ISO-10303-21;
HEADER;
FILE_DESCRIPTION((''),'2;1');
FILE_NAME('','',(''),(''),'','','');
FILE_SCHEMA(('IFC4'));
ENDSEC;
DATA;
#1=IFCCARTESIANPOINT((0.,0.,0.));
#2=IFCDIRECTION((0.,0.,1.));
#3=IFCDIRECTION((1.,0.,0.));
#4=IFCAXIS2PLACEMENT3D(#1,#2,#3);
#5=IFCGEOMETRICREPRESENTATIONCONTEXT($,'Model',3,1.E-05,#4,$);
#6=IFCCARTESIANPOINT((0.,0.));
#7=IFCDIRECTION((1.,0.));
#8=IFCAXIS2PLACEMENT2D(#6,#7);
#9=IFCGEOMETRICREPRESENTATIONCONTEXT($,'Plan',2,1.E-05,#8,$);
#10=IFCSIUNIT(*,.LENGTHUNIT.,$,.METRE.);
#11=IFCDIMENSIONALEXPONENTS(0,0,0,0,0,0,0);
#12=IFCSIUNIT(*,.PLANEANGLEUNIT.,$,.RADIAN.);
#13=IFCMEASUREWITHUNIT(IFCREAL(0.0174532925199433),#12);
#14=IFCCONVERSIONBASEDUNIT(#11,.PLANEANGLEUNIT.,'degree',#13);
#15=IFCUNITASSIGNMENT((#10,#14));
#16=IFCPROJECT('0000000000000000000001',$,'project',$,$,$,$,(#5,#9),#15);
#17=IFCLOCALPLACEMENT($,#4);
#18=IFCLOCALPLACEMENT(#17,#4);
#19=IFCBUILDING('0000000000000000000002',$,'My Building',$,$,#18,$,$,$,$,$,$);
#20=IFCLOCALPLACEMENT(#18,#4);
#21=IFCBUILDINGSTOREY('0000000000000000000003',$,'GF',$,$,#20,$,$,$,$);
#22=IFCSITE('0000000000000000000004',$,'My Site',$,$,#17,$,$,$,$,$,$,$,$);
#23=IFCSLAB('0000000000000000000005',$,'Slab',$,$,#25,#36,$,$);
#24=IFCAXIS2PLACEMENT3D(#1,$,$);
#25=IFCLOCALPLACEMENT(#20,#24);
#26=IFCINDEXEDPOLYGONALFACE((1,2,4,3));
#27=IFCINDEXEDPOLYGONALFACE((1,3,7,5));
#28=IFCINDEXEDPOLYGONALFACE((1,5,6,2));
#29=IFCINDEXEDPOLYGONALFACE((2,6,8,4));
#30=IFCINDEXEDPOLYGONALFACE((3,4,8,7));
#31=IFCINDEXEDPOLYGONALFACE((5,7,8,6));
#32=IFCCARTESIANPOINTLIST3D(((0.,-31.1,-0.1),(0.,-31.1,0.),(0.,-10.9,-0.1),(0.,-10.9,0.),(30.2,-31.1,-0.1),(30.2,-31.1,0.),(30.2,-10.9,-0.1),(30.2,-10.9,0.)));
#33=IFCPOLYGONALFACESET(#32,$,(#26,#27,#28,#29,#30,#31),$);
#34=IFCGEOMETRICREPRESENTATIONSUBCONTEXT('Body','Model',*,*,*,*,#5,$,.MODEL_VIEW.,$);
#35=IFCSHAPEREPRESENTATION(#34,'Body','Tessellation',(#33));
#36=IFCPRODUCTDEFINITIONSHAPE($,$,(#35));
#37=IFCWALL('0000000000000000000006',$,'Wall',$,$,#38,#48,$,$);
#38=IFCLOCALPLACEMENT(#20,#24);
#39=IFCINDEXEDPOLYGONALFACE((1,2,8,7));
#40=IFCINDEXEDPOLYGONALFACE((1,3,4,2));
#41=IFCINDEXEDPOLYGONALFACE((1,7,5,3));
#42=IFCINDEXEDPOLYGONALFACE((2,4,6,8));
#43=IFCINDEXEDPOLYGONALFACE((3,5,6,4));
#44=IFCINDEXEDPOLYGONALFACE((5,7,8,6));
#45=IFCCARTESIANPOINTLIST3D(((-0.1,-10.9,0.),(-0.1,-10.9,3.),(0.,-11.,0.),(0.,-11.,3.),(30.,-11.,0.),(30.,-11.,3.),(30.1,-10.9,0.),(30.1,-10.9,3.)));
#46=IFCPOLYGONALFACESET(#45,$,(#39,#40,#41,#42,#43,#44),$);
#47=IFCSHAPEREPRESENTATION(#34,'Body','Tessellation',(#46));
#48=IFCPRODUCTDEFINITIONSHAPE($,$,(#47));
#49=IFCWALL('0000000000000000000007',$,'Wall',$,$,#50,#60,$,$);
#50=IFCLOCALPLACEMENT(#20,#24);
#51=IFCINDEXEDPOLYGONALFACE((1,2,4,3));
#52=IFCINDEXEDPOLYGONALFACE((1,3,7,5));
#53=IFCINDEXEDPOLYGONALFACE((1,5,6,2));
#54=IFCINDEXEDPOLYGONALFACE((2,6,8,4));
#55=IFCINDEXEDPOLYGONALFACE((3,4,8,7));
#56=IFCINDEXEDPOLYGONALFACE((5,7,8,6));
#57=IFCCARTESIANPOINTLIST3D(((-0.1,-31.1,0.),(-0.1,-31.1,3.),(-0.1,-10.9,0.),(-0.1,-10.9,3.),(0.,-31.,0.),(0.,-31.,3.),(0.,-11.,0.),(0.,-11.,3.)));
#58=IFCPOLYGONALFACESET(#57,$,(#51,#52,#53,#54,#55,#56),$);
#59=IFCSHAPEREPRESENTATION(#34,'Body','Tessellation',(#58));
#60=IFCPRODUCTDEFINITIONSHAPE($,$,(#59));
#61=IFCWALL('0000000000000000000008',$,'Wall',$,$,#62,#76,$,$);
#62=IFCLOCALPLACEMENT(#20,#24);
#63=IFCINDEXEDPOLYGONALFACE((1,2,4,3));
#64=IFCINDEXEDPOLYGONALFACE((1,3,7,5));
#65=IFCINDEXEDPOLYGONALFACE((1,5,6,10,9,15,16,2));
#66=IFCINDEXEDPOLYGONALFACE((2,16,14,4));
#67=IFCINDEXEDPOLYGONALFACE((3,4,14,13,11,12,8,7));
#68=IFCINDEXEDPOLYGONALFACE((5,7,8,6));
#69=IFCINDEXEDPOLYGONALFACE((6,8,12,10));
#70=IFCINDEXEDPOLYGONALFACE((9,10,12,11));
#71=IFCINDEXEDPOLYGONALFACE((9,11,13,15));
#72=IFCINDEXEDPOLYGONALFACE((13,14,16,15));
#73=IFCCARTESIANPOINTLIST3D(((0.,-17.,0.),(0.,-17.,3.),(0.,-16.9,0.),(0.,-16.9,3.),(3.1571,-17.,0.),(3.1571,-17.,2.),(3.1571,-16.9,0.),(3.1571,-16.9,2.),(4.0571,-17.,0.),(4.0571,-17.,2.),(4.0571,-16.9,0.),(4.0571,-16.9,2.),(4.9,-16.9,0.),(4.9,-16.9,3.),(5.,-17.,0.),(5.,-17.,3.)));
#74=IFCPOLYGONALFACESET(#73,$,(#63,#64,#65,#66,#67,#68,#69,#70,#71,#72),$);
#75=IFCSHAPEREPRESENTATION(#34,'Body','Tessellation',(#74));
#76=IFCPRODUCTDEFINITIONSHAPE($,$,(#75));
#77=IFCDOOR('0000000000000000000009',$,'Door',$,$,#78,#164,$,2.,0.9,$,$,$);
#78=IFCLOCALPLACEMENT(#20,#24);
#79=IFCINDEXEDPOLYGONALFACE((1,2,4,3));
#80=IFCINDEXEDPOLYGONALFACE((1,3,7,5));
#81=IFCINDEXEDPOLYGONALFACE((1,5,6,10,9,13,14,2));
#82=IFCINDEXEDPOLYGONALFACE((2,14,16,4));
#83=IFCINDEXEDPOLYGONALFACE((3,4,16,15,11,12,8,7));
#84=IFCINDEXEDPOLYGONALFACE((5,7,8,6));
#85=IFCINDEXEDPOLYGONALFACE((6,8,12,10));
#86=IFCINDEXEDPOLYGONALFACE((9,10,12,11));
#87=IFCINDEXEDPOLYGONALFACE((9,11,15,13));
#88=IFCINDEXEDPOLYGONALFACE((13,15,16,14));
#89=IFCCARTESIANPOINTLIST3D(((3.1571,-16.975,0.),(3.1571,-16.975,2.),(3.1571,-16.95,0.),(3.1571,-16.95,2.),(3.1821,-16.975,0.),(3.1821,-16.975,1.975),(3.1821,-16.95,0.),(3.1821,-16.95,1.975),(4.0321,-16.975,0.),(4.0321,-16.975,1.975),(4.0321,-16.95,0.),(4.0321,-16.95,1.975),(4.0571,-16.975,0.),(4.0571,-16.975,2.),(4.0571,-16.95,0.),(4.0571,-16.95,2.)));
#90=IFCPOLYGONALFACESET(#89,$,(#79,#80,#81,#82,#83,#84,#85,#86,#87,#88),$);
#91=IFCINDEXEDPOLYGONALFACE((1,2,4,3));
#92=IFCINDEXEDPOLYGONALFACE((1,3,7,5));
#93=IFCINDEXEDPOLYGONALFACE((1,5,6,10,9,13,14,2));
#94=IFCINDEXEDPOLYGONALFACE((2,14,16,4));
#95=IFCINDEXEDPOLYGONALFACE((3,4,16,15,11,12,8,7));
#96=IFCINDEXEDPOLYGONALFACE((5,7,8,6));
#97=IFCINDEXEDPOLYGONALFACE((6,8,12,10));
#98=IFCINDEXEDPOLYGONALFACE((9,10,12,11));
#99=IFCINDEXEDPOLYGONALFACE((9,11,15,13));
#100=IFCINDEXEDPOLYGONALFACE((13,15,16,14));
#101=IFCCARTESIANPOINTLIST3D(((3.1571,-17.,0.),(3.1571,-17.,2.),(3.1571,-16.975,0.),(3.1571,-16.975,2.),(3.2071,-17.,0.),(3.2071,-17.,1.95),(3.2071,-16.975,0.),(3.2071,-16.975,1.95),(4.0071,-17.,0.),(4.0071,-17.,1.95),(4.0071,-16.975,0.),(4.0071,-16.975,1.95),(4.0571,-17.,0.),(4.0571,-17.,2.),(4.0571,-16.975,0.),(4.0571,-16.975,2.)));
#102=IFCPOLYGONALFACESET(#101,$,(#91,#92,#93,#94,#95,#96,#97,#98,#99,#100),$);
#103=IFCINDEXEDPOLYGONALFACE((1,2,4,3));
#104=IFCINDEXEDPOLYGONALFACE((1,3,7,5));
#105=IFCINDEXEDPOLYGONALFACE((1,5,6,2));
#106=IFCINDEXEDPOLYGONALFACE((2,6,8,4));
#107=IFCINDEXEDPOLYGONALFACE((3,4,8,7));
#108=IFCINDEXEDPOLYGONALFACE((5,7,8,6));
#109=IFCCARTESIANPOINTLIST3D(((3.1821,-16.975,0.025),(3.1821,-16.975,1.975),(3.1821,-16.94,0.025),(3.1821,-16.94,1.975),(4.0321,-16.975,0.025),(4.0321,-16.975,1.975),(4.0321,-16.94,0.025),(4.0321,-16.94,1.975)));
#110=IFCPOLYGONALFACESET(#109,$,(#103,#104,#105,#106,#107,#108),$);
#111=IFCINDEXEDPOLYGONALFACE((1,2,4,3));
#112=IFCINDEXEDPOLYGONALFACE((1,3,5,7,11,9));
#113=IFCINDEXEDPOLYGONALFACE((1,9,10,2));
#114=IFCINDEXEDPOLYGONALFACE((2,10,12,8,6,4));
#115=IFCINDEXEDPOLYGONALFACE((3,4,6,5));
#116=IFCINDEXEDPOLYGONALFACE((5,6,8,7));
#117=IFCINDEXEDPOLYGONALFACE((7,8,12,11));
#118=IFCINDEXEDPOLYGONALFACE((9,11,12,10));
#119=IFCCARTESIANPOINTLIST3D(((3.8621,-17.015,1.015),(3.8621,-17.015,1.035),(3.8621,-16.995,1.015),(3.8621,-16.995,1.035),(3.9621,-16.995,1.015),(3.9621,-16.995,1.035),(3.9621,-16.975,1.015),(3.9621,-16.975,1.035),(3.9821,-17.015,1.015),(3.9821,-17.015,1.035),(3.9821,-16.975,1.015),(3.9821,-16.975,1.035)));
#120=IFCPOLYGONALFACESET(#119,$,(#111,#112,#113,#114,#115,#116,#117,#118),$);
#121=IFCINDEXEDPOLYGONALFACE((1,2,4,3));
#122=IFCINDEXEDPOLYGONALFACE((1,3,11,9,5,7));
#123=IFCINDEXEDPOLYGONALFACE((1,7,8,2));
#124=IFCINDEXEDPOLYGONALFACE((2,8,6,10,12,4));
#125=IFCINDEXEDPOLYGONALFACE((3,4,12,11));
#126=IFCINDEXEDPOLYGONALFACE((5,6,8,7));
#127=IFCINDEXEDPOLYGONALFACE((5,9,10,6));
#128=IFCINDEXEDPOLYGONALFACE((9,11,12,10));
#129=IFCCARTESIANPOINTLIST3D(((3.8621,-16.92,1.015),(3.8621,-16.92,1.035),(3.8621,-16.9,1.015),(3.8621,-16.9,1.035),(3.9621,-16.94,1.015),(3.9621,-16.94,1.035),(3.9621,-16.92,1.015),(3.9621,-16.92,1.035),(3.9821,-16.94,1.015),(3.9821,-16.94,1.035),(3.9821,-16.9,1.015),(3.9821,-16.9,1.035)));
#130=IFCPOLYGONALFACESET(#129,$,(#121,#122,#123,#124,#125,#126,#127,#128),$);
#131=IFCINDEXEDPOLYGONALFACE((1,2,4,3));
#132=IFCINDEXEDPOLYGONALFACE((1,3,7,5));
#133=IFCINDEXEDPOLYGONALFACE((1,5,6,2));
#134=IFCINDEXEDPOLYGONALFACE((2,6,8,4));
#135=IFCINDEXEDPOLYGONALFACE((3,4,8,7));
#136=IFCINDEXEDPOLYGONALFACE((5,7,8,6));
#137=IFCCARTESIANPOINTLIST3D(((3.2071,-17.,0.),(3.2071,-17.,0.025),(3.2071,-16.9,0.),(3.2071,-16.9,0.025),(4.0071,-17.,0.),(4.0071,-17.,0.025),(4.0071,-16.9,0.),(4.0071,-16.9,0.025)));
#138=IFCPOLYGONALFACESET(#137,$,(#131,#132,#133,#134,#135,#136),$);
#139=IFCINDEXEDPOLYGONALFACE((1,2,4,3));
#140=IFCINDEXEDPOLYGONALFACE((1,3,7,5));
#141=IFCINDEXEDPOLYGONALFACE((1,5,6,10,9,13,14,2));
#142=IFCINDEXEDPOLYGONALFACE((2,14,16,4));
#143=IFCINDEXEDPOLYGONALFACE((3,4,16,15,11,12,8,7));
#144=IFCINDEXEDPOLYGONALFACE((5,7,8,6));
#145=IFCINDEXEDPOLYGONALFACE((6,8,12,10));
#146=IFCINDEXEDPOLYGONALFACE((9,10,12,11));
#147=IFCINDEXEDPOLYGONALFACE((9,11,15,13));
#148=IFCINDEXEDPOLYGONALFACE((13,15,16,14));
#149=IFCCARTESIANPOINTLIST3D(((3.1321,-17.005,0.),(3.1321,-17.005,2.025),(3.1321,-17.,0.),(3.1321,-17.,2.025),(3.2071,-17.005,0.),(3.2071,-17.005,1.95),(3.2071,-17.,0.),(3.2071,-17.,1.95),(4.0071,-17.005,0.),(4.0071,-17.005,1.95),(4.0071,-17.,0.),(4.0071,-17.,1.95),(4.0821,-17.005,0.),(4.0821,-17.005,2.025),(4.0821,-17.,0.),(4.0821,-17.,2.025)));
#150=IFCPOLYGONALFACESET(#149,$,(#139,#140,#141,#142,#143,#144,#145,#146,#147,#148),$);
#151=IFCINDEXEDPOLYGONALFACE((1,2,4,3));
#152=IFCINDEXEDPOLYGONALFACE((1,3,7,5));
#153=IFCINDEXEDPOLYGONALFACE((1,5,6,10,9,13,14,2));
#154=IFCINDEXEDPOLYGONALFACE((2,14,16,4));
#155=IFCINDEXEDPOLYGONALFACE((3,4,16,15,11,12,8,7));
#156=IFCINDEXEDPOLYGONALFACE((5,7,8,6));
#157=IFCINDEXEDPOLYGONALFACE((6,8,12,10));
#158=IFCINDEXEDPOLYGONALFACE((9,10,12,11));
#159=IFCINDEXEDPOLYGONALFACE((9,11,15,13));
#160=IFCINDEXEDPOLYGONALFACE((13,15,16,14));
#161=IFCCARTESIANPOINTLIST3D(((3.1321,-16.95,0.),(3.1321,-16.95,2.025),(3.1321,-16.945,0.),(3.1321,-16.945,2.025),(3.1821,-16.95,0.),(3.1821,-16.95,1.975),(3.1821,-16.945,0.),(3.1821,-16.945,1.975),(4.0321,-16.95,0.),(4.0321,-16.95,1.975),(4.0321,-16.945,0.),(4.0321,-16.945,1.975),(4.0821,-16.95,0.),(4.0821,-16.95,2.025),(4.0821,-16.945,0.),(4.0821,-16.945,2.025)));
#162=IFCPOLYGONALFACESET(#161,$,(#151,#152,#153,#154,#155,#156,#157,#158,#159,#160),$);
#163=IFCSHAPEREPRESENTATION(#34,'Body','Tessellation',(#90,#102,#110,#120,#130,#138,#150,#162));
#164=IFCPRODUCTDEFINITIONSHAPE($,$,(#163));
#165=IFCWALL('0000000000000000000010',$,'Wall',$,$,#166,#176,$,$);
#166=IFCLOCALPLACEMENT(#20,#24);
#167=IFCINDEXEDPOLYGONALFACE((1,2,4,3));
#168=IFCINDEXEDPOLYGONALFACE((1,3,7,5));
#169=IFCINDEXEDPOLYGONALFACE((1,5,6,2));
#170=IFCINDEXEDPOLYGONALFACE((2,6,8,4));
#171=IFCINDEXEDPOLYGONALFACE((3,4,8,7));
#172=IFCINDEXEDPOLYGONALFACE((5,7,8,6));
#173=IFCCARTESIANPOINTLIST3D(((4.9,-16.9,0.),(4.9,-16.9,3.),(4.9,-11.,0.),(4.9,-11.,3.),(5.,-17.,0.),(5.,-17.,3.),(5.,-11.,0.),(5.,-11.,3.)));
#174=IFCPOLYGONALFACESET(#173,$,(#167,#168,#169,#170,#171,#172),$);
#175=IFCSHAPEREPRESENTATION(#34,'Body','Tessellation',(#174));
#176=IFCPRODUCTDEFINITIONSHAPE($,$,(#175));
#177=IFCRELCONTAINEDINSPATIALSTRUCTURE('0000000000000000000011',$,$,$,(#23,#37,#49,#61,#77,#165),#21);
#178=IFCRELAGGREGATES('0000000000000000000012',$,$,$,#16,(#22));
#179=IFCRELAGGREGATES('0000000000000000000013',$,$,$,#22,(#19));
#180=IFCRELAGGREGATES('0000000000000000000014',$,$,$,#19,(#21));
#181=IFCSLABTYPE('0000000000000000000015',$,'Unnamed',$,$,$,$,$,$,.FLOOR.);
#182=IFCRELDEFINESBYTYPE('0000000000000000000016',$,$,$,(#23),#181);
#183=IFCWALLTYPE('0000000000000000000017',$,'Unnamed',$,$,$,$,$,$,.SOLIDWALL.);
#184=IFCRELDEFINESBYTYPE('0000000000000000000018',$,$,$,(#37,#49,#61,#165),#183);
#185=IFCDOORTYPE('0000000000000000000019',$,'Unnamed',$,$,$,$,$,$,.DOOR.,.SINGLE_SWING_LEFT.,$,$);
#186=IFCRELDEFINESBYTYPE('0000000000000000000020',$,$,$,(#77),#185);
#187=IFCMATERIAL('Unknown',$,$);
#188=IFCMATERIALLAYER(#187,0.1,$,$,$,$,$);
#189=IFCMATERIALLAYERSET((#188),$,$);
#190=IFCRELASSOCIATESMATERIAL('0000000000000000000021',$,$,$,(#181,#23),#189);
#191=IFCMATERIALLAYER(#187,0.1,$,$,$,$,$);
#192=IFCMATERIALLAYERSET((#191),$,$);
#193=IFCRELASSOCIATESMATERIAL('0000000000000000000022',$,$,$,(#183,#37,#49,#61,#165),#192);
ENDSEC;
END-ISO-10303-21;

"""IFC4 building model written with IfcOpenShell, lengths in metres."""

from ifc_helpers import new_model, entity, si_unit, converted_unit, frame, origin_with_axes, origin_2d_with_axis, place, context, subcontext, project, spatial, line, indexed_curve, outline, extrude, shape, source, transform, mapped, material, layer, layer_set, layer_usage, type_object, type_shapes, element, fill, save


model = new_model("IFC4")

# Units and contexts
model_context = context("Model", 3, precision=1e-05, world=origin_with_axes())
plan_context = context("Plan", 2, precision=1e-05, world=origin_2d_with_axis())
body_context_1 = subcontext(model_context, "Body", "Model", "MODEL_VIEW")
body_context_2 = subcontext(plan_context, "Body", "Plan", "PLAN_VIEW")
ifc_project = project(units=[si_unit("LENGTHUNIT", "METRE"), converted_unit("PLANEANGLEUNIT", "degree", entity("IfcReal", 0.0174532925199433), si_unit("PLANEANGLEUNIT", "RADIAN"), dimensions=[0, 0, 0, 0, 0, 0, 0])], contexts=[model_context, plan_context])

# Site, building, storey
site_placement = place(None, origin_with_axes())
site = spatial("IfcSite", under=ifc_project, at=site_placement, Name="My Site")
building_placement = place(site_placement, origin_with_axes())
building = spatial("IfcBuilding", under=site, at=building_placement, Name="My Building")
storey_placement = place(building_placement, origin_with_axes())
storey = spatial("IfcBuildingStorey", under=building, at=storey_placement, Name="GF")

# Slab
ifc_material = material(Name="Unknown")
ifc_layer_1 = layer(ifc_material, 0.1)
ifc_layer_set_1 = layer_set([ifc_layer_1])
ifc_layer_usage_1 = layer_usage(ifc_layer_set_1, "AXIS3", "POSITIVE", -0.1)
slab_type = type_object("IfcSlabType", Name="Unnamed", PredefinedType="FLOOR", material=ifc_layer_set_1)
slab_placement = place(storey_placement, frame((0.0, -10.9, 0.0), z_axis=(0.0, 0.0, 1.0), x_axis=(1.0, 0.0, 0.0)))
element("IfcSlab", 1, at=slab_placement, inside=storey, type_object=slab_type, material=ifc_layer_usage_1, Name="Slab", context=body_context_1, shape_type="SweptSolid", body=[
    extrude(outline(indexed_curve([(0.0, 0.0), (30.2, 0.0), (30.2, -20.2), (0.0, -20.2), (0.0, 0.0)])), frame((0.0, 0.0, -0.1), z_axis=(0.0, 0.0, 1.0), x_axis=(1.0, 0.0, 0.0)), (0.0, 0.0, 1.0), 0.1),
])

# Walls
ifc_layer_2 = layer(ifc_material, 0.1)
ifc_layer_set_2 = layer_set([ifc_layer_2])
ifc_layer_usage_2 = layer_usage(ifc_layer_set_2, "AXIS2", "POSITIVE", 0.0)
wall_type = type_object("IfcWallType", Name="Unnamed", PredefinedType="SOLIDWALL", material=ifc_layer_set_2)
wall_1_placement = place(storey_placement, frame((0.0, -11.0, 0.0), z_axis=(0.0, 0.0, 1.0), x_axis=(1.0, 0.0, 0.0)))
element("IfcWall", 2, at=wall_1_placement, inside=storey, type_object=wall_type, material=ifc_layer_usage_2, Name="Wall", context=body_context_1, shape_type="SweptSolid", body=[
    extrude(outline(indexed_curve([(0.0, 0.0), (-0.1, 0.1), (30.1, 0.1), (30.0, 0.0)], segments=[line(1, 2, 3, 4, 1)])), origin_with_axes(), (0.0, 0.0, 1.0), 3.0),
])
ifc_layer_usage_3 = layer_usage(ifc_layer_set_2, "AXIS2", "POSITIVE", 0.0)
wall_2_placement = place(storey_placement, frame((0.0, -31.0, 0.0), z_axis=(0.0, 0.0, 1.0), x_axis=(0.0, 1.0, 0.0)))
element("IfcWall", 3, at=wall_2_placement, inside=storey, type_object=wall_type, material=ifc_layer_usage_3, Name="Wall", context=body_context_1, shape_type="SweptSolid", body=[
    extrude(outline(indexed_curve([(0.0, 0.0), (-0.1, 0.1), (20.1, 0.1), (20.0, 0.0)], segments=[line(1, 2, 3, 4, 1)])), origin_with_axes(), (0.0, 0.0, 1.0), 3.0),
])

# Wall, opening, door
ifc_layer_usage_4 = layer_usage(ifc_layer_set_2, "AXIS2", "POSITIVE", 0.0)
wall_3_placement = place(storey_placement, frame((0.0, -17.0, 0.0), z_axis=(0.0, 0.0, 1.0), x_axis=(1.0, 0.0, 0.0)))
wall_3 = element("IfcWall", 4, at=wall_3_placement, inside=storey, type_object=wall_type, material=ifc_layer_usage_4, Name="Wall", context=body_context_1, shape_type="SweptSolid", body=[
    extrude(outline(indexed_curve([(0.0, 0.0), (0.0, 0.1), (4.9, 0.1), (5.0, 0.0)], segments=[line(1, 2, 3, 4, 1)])), origin_with_axes(), (0.0, 0.0, 1.0), 3.0),
])
shared_shape_1 = source(origin_with_axes(), body_context_1, "Body", "SweptSolid", [
    extrude(outline(indexed_curve([(0.0, 0.0), (0.9, 0.0), (0.9, 2.0), (0.0, 2.0)], segments=[line(1, 2, 3, 4, 1)])), frame((0.0, -0.6, 0.0), z_axis=(0.0, -1.0, 0.0), x_axis=(1.0, 0.0, 0.0)), (0.0, 0.0, -1.0), 1.2),
])
opening_1_placement = place(wall_3_placement, frame((3.1571, 0.0, 0.0), z_axis=(0.0, 0.0, 1.0), x_axis=(1.0, 0.0, 0.0)))
opening_1 = element("IfcOpeningElement", 5, at=opening_1_placement, cuts=wall_3, PredefinedType="OPENING", context=body_context_1, shape_type="MappedRepresentation", body=[
    mapped(shared_shape_1, transform((0.0, 0.0, 0.0), x_axis=(1.0, 0.0, 0.0), y_axis=(0.0, 1.0, 0.0), z_axis=(0.0, 0.0, 1.0), scale=1.0)),
])
door_type = type_object("IfcDoorType", Name="Unnamed", OperationType="SINGLE_SWING_LEFT", PredefinedType="DOOR")
shared_shape_2 = source(origin_with_axes(), body_context_1, "Body", "SweptSolid", [
    extrude(outline(indexed_curve([(0.0, 0.0), (0.0, 2.0), (0.9, 2.0), (0.9, 0.0), (0.875, 0.0), (0.875, 1.975), (0.025, 1.975), (0.025, 0.0)], segments=[line(1, 2, 3, 4, 5, 6, 7, 8, 1)])), frame((0.0, 0.025, 0.0), z_axis=(0.0, -1.0, 0.0), x_axis=(1.0, 0.0, 0.0)), (0.0, 0.0, -1.0), 0.025),
    extrude(outline(indexed_curve([(0.0, 0.0), (0.0, 2.0), (0.9, 2.0), (0.9, 0.0), (0.85, 0.0), (0.85, 1.95), (0.05, 1.95), (0.05, 0.0)], segments=[line(1, 2, 3, 4, 5, 6, 7, 8, 1)])), frame((0.0, 0.0, 0.0), z_axis=(0.0, -1.0, 0.0), x_axis=(1.0, 0.0, 0.0)), (0.0, 0.0, -1.0), 0.025),
    extrude(outline(indexed_curve([(0.0, 0.0), (0.85, 0.0), (0.85, 0.035), (0.0, 0.035)], segments=[line(1, 2, 3, 4, 1)])), frame((0.025, 0.025, 0.025), z_axis=(0.0, 0.0, 1.0), x_axis=(1.0, 0.0, 0.0)), (0.0, 0.0, 1.0), 1.95),
    extrude(outline(indexed_curve([(0.0, 0.0), (0.0, -0.04), (-0.12, -0.04), (-0.12, -0.02), (-0.02, -0.02), (-0.02, 0.0)], segments=[line(1, 2, 3, 4, 5, 6, 1)])), frame((0.825, 0.025, 1.015), z_axis=(0.0, 0.0, 1.0), x_axis=(1.0, 0.0, 0.0)), (0.0, 0.0, 1.0), 0.02),
    extrude(outline(indexed_curve([(0.0, 0.0), (0.0, 0.04), (-0.12, 0.04), (-0.12, 0.02), (-0.02, 0.02), (-0.02, 0.0)], segments=[line(1, 2, 3, 4, 5, 6, 1)])), frame((0.825, 0.06, 1.015), z_axis=(0.0, 0.0, 1.0), x_axis=(1.0, 0.0, 0.0)), (0.0, 0.0, 1.0), 0.02),
    extrude(outline(indexed_curve([(0.0, 0.0), (0.8, 0.0), (0.8, 0.1), (0.0, 0.1)], segments=[line(1, 2, 3, 4, 1)])), frame((0.05, 0.0, 0.0), z_axis=(0.0, 0.0, 1.0), x_axis=(1.0, 0.0, 0.0)), (0.0, 0.0, 1.0), 0.025),
    extrude(outline(indexed_curve([(0.0, 0.0), (0.0, 2.025), (0.95, 2.025), (0.95, 0.0), (0.875, 0.0), (0.875, 1.95), (0.075, 1.95), (0.075, 0.0)], segments=[line(1, 2, 3, 4, 5, 6, 7, 8, 1)])), frame((-0.025, -0.005, 0.0), z_axis=(0.0, -1.0, 0.0), x_axis=(1.0, 0.0, 0.0)), (0.0, 0.0, -1.0), 0.005),
    extrude(outline(indexed_curve([(0.0, 0.0), (0.0, 2.025), (0.95, 2.025), (0.95, 0.0), (0.9, 0.0), (0.9, 1.975), (0.05, 1.975), (0.05, 0.0)], segments=[line(1, 2, 3, 4, 5, 6, 7, 8, 1)])), frame((-0.025, 0.05, 0.0), z_axis=(0.0, -1.0, 0.0), x_axis=(1.0, 0.0, 0.0)), (0.0, 0.0, -1.0), 0.005),
])
shared_shape_3 = source(origin_with_axes(), body_context_2, "Body", "Curve2D", [
    entity("IfcIndexedPolyCurve", entity("IfcCartesianPointList2D", [[0.0, 0.0], [0.0, 0.05], [0.025, 0.05], [0.025, 0.025], [0.05, 0.025], [0.05, 0.0]]), [entity("IfcLineIndex", [1, 2, 3, 4, 5, 6, 1])]),
    entity("IfcIndexedPolyCurve", entity("IfcCartesianPointList2D", [[0.9, 0.0], [0.9, 0.05], [0.875, 0.05], [0.875, 0.025], [0.85, 0.025], [0.85, 0.0]]), [entity("IfcLineIndex", [1, 2, 3, 4, 5, 6, 1])]),
    entity("IfcTrimmedCurve", entity("IfcEllipse", entity("IfcAxis2Placement2D", entity("IfcCartesianPoint", [0.06, 0.05]), entity("IfcDirection", [1.0, 0.0])), 0.815, 0.85), [entity("IfcCartesianPoint", [0.875, 0.05])], [entity("IfcCartesianPoint", [0.06, 0.9])], True, "CARTESIAN"),
    entity("IfcIndexedPolyCurve", entity("IfcCartesianPointList2D", [[0.025, 0.05], [0.06, 0.05], [0.06, 0.9], [0.025, 0.9]]), [entity("IfcLineIndex", [1, 2, 3, 4, 1])]),
])
type_shapes(door_type, [shared_shape_2, shared_shape_3])
door_1_placement = place(opening_1_placement, origin_with_axes())
door_1 = element("IfcDoor", 6, at=door_1_placement, inside=storey, type_object=door_type, Name="Door", OverallHeight=2.0, OverallWidth=0.9, shapes=[
    shape(body_context_1, "Body", "MappedRepresentation", [mapped(shared_shape_2, transform((0.0, 0.0, 0.0), x_axis=(1.0, 0.0, 0.0), y_axis=(0.0, 1.0, 0.0), z_axis=(0.0, 0.0, 1.0), scale=1.0))]),
    shape(body_context_2, "Body", "MappedRepresentation", [mapped(shared_shape_3, transform((0.0, 0.0, 0.0), x_axis=(1.0, 0.0, 0.0), y_axis=(0.0, 1.0, 0.0), z_axis=(0.0, 0.0, 1.0), scale=1.0))]),
])
fill(opening_1, door_1)

# Wall
ifc_layer_usage_5 = layer_usage(ifc_layer_set_2, "AXIS2", "POSITIVE", 0.0)
wall_4_placement = place(storey_placement, frame((5.0, -17.0, 0.0), z_axis=(0.0, 0.0, 1.0), x_axis=(0.0, 1.0, 0.0)))
element("IfcWall", 7, at=wall_4_placement, inside=storey, type_object=wall_type, material=ifc_layer_usage_5, Name="Wall", context=body_context_1, shape_type="SweptSolid", body=[
    extrude(outline(indexed_curve([(0.0, 0.0), (0.1, 0.1), (6.0, 0.1), (6.0, 0.0)], segments=[line(1, 2, 3, 4, 1)])), origin_with_axes(), (0.0, 0.0, 1.0), 3.0),
])

save(model, "model.ifc")
